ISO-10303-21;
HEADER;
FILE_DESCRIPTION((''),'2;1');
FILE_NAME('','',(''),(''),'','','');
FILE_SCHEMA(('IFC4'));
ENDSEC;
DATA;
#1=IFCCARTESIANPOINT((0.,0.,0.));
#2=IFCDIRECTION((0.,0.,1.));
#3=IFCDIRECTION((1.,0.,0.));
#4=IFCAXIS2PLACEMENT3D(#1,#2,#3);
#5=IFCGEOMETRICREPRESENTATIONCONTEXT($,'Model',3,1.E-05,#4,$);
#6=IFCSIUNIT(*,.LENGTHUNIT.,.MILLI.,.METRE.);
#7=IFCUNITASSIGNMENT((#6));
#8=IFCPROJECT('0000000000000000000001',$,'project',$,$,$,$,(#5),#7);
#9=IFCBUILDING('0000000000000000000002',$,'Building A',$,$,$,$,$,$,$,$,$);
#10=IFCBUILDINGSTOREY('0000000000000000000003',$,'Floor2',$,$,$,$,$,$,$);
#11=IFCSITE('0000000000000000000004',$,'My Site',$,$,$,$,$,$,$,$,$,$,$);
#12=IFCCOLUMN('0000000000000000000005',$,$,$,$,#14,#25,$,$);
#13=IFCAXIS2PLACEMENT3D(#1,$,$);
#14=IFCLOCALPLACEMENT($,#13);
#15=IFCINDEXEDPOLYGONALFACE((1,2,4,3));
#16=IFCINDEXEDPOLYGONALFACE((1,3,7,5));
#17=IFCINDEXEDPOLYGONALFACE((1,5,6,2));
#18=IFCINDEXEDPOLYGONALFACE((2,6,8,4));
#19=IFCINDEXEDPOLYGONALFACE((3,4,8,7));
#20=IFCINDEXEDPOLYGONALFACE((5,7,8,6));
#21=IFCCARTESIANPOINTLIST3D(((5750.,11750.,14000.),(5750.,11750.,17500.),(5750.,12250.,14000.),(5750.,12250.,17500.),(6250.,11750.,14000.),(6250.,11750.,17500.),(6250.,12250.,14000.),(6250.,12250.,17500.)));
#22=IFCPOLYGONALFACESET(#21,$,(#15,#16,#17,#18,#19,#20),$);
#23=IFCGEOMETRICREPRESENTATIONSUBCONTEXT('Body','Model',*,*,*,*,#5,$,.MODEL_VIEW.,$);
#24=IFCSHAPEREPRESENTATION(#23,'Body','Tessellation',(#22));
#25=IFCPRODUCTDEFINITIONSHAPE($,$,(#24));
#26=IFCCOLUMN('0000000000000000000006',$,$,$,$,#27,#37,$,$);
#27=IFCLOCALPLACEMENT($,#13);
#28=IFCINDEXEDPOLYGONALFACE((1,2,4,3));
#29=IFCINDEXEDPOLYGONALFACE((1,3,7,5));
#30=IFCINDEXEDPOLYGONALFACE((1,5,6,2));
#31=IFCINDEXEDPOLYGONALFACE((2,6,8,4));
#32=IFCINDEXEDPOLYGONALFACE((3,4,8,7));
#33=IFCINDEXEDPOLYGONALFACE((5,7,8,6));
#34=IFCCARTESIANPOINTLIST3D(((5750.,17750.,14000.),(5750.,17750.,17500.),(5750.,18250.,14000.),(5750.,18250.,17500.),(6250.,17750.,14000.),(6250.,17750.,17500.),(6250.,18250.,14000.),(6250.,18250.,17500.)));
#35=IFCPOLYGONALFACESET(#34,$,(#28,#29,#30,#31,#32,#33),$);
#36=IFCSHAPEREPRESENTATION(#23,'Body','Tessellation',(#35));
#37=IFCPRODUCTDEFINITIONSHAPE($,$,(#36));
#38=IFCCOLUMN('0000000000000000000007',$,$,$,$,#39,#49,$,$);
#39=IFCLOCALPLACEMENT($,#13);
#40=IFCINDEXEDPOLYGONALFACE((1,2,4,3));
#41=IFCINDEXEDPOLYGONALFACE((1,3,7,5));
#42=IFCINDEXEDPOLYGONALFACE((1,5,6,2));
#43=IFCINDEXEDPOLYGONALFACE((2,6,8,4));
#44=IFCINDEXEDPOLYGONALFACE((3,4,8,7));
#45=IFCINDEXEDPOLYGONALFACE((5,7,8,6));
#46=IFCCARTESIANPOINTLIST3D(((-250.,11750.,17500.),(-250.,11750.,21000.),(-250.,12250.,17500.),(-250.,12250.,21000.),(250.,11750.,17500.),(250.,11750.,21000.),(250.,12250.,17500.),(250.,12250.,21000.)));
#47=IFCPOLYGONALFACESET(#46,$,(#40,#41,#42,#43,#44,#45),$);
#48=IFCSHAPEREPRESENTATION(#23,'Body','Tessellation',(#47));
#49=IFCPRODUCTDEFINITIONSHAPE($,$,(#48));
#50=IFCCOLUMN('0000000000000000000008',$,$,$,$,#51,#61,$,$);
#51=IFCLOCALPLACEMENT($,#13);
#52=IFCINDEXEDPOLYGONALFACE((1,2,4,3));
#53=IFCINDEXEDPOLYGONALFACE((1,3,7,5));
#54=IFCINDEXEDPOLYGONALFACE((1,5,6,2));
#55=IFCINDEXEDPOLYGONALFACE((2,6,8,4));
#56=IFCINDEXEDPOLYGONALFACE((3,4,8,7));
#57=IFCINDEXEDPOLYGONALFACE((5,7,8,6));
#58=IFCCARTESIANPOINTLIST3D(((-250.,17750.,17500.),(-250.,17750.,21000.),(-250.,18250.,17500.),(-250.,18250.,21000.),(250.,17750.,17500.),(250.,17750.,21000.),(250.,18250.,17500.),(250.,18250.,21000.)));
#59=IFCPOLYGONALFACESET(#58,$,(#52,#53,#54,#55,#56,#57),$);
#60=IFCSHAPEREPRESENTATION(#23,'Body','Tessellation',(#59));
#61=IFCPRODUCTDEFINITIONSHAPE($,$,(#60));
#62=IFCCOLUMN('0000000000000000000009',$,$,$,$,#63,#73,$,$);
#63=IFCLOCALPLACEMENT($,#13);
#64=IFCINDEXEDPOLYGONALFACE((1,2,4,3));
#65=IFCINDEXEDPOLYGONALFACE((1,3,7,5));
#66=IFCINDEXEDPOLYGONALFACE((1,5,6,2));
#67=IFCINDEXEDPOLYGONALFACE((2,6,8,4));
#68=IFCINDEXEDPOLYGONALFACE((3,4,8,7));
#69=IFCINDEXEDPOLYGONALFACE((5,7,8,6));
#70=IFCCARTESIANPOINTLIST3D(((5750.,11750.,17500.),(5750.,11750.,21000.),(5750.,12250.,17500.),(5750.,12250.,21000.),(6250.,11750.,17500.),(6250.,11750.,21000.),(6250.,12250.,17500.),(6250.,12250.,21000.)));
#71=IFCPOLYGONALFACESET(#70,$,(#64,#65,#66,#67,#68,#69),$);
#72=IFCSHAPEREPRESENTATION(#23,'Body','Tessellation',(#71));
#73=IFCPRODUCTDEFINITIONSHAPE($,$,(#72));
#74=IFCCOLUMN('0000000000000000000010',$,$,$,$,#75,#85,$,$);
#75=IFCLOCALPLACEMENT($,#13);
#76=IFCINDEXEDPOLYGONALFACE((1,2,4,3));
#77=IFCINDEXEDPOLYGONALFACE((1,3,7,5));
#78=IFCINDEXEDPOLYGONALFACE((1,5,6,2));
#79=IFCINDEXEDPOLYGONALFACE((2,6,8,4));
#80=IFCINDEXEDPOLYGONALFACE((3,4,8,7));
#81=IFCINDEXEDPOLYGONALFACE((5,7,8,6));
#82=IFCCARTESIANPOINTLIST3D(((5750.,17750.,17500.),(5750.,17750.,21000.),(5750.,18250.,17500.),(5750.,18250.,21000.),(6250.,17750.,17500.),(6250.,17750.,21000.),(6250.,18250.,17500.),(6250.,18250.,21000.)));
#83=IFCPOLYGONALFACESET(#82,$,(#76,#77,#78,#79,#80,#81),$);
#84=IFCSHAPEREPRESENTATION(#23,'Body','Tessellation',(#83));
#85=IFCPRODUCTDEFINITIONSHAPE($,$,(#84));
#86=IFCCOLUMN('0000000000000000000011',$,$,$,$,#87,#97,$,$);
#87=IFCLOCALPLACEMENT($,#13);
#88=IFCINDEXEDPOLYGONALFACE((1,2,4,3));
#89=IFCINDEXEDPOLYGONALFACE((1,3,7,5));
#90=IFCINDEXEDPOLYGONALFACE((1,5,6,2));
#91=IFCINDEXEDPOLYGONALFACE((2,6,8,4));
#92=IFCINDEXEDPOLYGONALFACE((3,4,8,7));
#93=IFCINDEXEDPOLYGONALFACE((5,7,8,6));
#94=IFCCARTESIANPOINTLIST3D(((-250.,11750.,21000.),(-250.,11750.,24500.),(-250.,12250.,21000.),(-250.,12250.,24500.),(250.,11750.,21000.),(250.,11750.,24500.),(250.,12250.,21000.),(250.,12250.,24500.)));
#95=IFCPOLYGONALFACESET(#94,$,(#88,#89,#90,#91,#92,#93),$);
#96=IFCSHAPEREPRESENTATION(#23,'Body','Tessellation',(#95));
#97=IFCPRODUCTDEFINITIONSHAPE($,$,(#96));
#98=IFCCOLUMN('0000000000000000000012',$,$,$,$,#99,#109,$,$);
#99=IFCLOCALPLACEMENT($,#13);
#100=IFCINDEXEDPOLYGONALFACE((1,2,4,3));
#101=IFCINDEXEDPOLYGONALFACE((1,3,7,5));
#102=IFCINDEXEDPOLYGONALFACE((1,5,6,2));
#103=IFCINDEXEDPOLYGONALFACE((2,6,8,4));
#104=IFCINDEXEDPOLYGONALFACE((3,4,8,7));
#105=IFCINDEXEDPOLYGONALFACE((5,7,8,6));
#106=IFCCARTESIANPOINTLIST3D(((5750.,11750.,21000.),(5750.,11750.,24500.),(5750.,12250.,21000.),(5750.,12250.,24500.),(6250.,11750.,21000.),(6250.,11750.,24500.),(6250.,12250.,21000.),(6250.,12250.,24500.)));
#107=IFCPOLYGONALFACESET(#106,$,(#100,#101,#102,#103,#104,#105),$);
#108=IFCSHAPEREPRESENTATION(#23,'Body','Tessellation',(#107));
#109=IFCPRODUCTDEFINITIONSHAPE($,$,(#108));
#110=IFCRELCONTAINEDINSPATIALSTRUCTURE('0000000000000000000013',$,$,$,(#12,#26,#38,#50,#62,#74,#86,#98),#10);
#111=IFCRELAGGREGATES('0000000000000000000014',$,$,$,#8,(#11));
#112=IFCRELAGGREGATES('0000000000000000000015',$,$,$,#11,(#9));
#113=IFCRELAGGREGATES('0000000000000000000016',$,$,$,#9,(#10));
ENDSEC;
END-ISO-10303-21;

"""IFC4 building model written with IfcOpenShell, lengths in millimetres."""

from ifc_helpers import new_model, si_unit, frame, origin_with_axes, place, context, subcontext, project, spatial, line, indexed_curve, outline, extrude, element, save


model = new_model("IFC4")

# Units and contexts
model_context = context("Model", 3, precision=1e-05, world=origin_with_axes())
body_context = subcontext(model_context, "Body", "Model", "MODEL_VIEW")
ifc_project = project(units=[si_unit("LENGTHUNIT", "METRE", prefix="MILLI")], contexts=[model_context])

# Site, building, storey
site = spatial("IfcSite", under=ifc_project, Name="My Site")
building = spatial("IfcBuilding", under=site, Name="Building A")
storey = spatial("IfcBuildingStorey", under=building, Name="Floor2")

# Columns
for number, where, z_axis, x_axis in (
    (1, (6000.0, 12000.0, 14000.0), (0.0, 0.0, 1.0), (1.0, 0.0, 0.0)),
    (2, (6000.0, 18000.0, 14000.0), (0.0, 0.0, 1.0), (1.0, 0.0, 0.0)),
    (3, (0.0, 12000.0, 17500.0), (0.0, 0.0, 1.0), (1.0, 0.0, 0.0)),
    (4, (0.0, 18000.0, 17500.0), (0.0, 0.0, 1.0), (1.0, 0.0, 0.0)),
    (5, (6000.0, 12000.0, 17500.0), (0.0, 0.0, 1.0), (1.0, 0.0, 0.0)),
    (6, (6000.0, 18000.0, 17500.0), (0.0, 0.0, 1.0), (1.0, 0.0, 0.0)),
    (7, (0.0, 12000.0, 21000.0), (0.0, 0.0, 1.0), (1.0, 0.0, 0.0)),
    (8, (6000.0, 12000.0, 21000.0), (0.0, 0.0, 1.0), (1.0, 0.0, 0.0)),
):
    element("IfcColumn", number, at=place(None, frame(where, z_axis=z_axis, x_axis=x_axis)), inside=storey, context=body_context, shape_type="SweptSolid", body=[
        extrude(outline(indexed_curve([(-250.0, -250.0), (250.0, -250.0), (250.0, 250.0), (-250.0, 250.0)], segments=[line(1, 2, 3, 4, 1)])), origin_with_axes(), (0.0, 0.0, 1.0), 3500.0),
    ])

save(model, "model.ifc")
